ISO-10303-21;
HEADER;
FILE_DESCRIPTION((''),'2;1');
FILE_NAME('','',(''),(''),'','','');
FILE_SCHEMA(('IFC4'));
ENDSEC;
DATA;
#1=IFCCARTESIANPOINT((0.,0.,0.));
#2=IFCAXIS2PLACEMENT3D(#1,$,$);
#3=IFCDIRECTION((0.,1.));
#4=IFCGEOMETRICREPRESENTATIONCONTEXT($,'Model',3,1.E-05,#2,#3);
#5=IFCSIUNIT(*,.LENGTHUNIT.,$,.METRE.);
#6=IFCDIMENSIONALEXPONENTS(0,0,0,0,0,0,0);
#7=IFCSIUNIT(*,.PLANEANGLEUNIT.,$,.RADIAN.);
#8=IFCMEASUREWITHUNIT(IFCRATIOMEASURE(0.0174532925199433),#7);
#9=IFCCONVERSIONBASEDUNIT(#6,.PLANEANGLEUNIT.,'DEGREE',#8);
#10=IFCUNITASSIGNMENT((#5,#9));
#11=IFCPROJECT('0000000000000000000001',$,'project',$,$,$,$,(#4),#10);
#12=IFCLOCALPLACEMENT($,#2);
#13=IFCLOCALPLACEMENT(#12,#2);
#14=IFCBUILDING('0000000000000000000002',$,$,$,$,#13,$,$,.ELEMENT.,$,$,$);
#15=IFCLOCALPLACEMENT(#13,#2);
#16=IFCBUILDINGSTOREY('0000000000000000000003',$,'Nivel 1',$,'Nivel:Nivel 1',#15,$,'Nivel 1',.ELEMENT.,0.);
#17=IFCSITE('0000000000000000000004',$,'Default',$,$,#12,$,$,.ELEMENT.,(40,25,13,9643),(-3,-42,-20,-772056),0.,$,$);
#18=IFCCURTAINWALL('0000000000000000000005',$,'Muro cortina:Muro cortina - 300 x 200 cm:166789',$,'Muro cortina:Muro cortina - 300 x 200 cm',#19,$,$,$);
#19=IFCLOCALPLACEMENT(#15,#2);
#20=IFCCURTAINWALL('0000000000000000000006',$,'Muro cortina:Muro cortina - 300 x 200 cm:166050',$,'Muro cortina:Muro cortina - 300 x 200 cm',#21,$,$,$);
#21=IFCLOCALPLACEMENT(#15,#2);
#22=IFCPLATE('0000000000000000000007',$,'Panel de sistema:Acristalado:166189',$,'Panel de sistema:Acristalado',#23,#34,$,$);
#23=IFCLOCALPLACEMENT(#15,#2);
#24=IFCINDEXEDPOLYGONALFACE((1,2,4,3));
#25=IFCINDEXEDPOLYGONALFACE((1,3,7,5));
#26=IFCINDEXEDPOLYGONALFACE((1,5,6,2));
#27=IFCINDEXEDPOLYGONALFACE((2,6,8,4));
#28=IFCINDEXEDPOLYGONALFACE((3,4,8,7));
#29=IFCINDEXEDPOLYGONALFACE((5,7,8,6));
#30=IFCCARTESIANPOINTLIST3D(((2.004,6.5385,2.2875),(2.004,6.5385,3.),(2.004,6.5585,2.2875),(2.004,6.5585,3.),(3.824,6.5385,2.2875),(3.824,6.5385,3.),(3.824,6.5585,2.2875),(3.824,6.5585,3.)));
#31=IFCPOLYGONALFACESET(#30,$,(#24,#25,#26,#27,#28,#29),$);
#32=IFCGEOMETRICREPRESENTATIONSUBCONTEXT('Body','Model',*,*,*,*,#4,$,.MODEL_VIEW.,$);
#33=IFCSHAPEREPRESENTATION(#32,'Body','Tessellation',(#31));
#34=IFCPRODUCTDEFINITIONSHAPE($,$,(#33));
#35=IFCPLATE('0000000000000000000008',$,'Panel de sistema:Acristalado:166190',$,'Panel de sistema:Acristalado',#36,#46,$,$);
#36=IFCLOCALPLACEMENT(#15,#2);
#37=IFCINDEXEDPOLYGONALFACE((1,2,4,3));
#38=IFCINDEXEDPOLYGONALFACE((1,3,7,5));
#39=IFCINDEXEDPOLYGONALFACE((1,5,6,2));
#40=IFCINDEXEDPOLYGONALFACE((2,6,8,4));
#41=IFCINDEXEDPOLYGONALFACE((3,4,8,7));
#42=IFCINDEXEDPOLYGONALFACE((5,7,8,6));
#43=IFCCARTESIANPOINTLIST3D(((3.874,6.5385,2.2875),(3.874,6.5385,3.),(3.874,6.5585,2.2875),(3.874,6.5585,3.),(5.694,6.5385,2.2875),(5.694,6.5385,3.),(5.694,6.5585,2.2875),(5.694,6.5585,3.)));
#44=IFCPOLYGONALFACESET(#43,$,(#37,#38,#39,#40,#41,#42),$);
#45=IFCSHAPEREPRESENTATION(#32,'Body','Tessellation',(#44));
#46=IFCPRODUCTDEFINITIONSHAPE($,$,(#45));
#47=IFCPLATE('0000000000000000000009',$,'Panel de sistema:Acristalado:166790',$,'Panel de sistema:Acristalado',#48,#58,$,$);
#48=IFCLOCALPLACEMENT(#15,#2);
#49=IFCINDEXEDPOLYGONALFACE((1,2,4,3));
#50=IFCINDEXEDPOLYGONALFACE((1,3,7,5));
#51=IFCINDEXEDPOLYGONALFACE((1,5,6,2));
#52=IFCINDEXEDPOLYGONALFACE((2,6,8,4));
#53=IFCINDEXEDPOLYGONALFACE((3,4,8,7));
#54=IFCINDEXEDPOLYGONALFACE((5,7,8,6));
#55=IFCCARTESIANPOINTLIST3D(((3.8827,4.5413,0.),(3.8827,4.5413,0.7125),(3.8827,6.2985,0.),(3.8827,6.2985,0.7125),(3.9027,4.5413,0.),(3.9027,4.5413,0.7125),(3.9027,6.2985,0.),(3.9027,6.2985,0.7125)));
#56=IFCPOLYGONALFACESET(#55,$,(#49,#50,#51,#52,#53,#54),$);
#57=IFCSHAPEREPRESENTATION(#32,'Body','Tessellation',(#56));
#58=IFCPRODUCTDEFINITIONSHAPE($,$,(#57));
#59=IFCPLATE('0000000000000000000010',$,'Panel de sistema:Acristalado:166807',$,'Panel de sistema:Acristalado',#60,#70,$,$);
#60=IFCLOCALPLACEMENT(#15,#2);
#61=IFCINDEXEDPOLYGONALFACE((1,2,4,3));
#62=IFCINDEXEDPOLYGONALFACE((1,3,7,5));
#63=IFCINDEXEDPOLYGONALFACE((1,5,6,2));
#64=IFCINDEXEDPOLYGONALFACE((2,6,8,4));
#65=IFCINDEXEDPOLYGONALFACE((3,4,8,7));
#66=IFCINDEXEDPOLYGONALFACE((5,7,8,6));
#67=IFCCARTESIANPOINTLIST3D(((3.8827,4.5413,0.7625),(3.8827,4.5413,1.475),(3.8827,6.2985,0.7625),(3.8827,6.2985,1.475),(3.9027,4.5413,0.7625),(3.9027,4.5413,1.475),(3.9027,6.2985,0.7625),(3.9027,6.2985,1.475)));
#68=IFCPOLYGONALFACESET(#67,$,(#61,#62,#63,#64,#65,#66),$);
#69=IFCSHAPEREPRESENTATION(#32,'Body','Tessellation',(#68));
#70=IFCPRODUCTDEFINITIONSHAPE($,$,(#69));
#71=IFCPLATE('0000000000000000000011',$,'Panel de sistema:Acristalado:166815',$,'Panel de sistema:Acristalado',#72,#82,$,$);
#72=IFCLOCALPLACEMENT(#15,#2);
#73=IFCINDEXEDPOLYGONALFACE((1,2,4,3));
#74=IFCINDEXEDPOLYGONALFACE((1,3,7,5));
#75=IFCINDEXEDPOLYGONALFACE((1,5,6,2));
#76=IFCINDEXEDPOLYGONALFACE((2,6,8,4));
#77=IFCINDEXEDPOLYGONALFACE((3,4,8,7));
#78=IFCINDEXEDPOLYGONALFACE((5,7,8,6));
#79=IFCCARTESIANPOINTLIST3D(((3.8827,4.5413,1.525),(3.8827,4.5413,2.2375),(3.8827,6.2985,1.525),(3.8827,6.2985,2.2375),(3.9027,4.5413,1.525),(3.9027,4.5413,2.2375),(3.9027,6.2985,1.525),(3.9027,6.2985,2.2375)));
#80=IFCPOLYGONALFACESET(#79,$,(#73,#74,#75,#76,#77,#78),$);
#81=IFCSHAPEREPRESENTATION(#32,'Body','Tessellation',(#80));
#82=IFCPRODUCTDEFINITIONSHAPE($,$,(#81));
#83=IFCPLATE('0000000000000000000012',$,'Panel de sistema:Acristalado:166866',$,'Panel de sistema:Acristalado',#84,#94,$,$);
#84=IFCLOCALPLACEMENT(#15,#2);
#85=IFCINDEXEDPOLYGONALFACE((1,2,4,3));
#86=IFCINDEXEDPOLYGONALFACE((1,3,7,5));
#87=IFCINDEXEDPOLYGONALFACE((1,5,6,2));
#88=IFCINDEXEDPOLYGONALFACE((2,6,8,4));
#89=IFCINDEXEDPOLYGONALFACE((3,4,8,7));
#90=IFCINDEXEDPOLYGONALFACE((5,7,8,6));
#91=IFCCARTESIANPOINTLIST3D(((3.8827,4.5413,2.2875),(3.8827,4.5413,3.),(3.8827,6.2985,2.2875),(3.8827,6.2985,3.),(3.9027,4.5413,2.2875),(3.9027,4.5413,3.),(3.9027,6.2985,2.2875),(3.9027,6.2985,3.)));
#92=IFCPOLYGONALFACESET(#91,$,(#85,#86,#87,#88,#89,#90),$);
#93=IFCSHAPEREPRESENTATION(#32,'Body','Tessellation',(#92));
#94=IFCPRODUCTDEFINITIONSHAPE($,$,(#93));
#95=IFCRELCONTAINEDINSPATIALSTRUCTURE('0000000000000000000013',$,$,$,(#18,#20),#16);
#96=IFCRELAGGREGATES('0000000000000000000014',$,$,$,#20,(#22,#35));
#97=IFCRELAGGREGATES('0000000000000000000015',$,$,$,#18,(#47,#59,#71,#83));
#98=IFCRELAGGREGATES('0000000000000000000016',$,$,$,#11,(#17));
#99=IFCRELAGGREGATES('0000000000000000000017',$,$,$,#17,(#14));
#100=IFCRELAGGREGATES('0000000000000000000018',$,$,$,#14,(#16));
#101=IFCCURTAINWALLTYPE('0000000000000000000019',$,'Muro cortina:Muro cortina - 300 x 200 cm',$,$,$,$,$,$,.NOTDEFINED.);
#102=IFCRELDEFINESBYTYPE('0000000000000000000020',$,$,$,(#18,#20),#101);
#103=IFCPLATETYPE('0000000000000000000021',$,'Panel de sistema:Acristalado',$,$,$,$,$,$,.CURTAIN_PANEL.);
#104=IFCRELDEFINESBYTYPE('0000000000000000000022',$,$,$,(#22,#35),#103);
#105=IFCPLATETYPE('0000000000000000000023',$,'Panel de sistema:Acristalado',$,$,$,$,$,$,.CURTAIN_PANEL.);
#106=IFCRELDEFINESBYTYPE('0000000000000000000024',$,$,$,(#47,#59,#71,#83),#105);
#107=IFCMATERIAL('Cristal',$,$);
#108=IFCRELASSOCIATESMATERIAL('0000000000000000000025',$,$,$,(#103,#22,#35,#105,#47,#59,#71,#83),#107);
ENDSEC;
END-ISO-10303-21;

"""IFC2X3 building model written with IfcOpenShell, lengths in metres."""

from ifc_helpers import new_model, entity, si_unit, converted_unit, direction, frame, origin, origin_2d_with_axis, place, context, subcontext, project, spatial, rectangle, extrude, source, transform, mapped, material, type_object, type_shapes, element, aggregate, save


model = new_model("IFC2X3")

# Units and contexts
model_context = context("Model", 3, precision=1e-05, world=origin(), true_north=direction((0.0, 1.0)))
body_context = subcontext(model_context, "Body", "Model", "MODEL_VIEW")
ifc_project = project(units=[si_unit("LENGTHUNIT", "METRE"), converted_unit("PLANEANGLEUNIT", "DEGREE", entity("IfcRatioMeasure", 0.0174532925199433), si_unit("PLANEANGLEUNIT", "RADIAN"), dimensions=[0, 0, 0, 0, 0, 0, 0])], contexts=[model_context])

# Site, building, storey
site_placement = place(None, origin())
site = spatial("IfcSite", under=ifc_project, at=site_placement, Name="Default", CompositionType="ELEMENT", RefLatitude=(40, 25, 13, 9643), RefLongitude=(-3, -42, -20, -772056), RefElevation=0.0)
building_placement = place(site_placement, origin())
building = spatial("IfcBuilding", under=site, at=building_placement, CompositionType="ELEMENT")
storey_placement = place(building_placement, origin())
storey = spatial("IfcBuildingStorey", under=building, at=storey_placement, Name="Nivel 1", ObjectType="Nivel:Nivel 1", LongName="Nivel 1", CompositionType="ELEMENT", Elevation=0.0)

# Curtain walls
curtain_wall_type = type_object("IfcCurtainWallType", Name="Muro cortina:Muro cortina - 300 x 200 cm", PredefinedType="NOTDEFINED")
curtain_wall_1_placement = place(storey_placement, origin())
curtain_wall_1 = element("IfcCurtainWall", 1, at=curtain_wall_1_placement, inside=storey, type_object=curtain_wall_type, Name="Muro cortina:Muro cortina - 300 x 200 cm:166789", ObjectType="Muro cortina:Muro cortina - 300 x 200 cm")
curtain_wall_2_placement = place(storey_placement, origin())
curtain_wall_2 = element("IfcCurtainWall", 2, at=curtain_wall_2_placement, inside=storey, type_object=curtain_wall_type, Name="Muro cortina:Muro cortina - 300 x 200 cm:166050", ObjectType="Muro cortina:Muro cortina - 300 x 200 cm")

# Plates
ifc_material_1 = material(Name="Cristal")
plate_type_1 = type_object("IfcPlateType", Name="Panel de sistema:Acristalado", PredefinedType="CURTAIN_PANEL", material=ifc_material_1)
shared_shape_1 = source(origin(), body_context, "Body", "SweptSolid", [
    extrude(rectangle(XDim=0.02, YDim=1.82, at=origin_2d_with_axis()), frame((0.0, 0.0, 0.0), z_axis=(0.0, 0.0, 1.0), x_axis=(0.0, 1.0, 0.0)), (0.0, 0.0, 1.0), 0.7125),
])
type_shapes(plate_type_1, [shared_shape_1])
plate_1_placement = place(curtain_wall_2_placement, frame((2.914, 6.5485, 2.2875)))
plate_1 = element("IfcPlate", 3, at=plate_1_placement, type_object=plate_type_1, material=ifc_material_1, Name="Panel de sistema:Acristalado:166189", ObjectType="Panel de sistema:Acristalado", context=body_context, shape_type="MappedRepresentation", body=[
    mapped(shared_shape_1, transform((0.0, 0.0, 0.0), scale=1.0)),
])
plate_2_placement = place(curtain_wall_2_placement, frame((4.784, 6.5485, 2.2875)))
plate_2 = element("IfcPlate", 4, at=plate_2_placement, type_object=plate_type_1, material=ifc_material_1, Name="Panel de sistema:Acristalado:166190", ObjectType="Panel de sistema:Acristalado", context=body_context, shape_type="MappedRepresentation", body=[
    mapped(shared_shape_1, transform((0.0, 0.0, 0.0), scale=1.0)),
])
aggregate(curtain_wall_2, [plate_1, plate_2])
plate_type_2 = type_object("IfcPlateType", Name="Panel de sistema:Acristalado", PredefinedType="CURTAIN_PANEL", material=ifc_material_1)
shared_shape_2 = source(origin(), body_context, "Body", "SweptSolid", [
    extrude(rectangle(XDim=0.02, YDim=1.7571, at=origin_2d_with_axis()), frame((0.0, 0.0, 0.0), z_axis=(0.0, 0.0, 1.0), x_axis=(0.0, 1.0, 0.0)), (0.0, 0.0, 1.0), 0.7125),
])
type_shapes(plate_type_2, [shared_shape_2])
plate_3_placement = place(curtain_wall_1_placement, frame((3.8927, 5.4199, 0.0), z_axis=(0.0, 0.0, 1.0), x_axis=(0.0, -1.0, 0.0)))
plate_3 = element("IfcPlate", 5, at=plate_3_placement, type_object=plate_type_2, material=ifc_material_1, Name="Panel de sistema:Acristalado:166790", ObjectType="Panel de sistema:Acristalado", context=body_context, shape_type="MappedRepresentation", body=[
    mapped(shared_shape_2, transform((0.0, 0.0, 0.0), scale=1.0)),
])
plate_4_placement = place(curtain_wall_1_placement, frame((3.8927, 5.4199, 0.7625), z_axis=(0.0, 0.0, 1.0), x_axis=(0.0, -1.0, 0.0)))
plate_4 = element("IfcPlate", 6, at=plate_4_placement, type_object=plate_type_2, material=ifc_material_1, Name="Panel de sistema:Acristalado:166807", ObjectType="Panel de sistema:Acristalado", context=body_context, shape_type="MappedRepresentation", body=[
    mapped(shared_shape_2, transform((0.0, 0.0, 0.0), scale=1.0)),
])
plate_5_placement = place(curtain_wall_1_placement, frame((3.8927, 5.4199, 1.525), z_axis=(0.0, 0.0, 1.0), x_axis=(0.0, -1.0, 0.0)))
plate_5 = element("IfcPlate", 7, at=plate_5_placement, type_object=plate_type_2, material=ifc_material_1, Name="Panel de sistema:Acristalado:166815", ObjectType="Panel de sistema:Acristalado", context=body_context, shape_type="MappedRepresentation", body=[
    mapped(shared_shape_2, transform((0.0, 0.0, 0.0), scale=1.0)),
])
plate_6_placement = place(curtain_wall_1_placement, frame((3.8927, 5.4199, 2.2875), z_axis=(0.0, 0.0, 1.0), x_axis=(0.0, -1.0, 0.0)))
plate_6 = element("IfcPlate", 8, at=plate_6_placement, type_object=plate_type_2, material=ifc_material_1, Name="Panel de sistema:Acristalado:166866", ObjectType="Panel de sistema:Acristalado", context=body_context, shape_type="MappedRepresentation", body=[
    mapped(shared_shape_2, transform((0.0, 0.0, 0.0), scale=1.0)),
])
aggregate(curtain_wall_1, [plate_3, plate_4, plate_5, plate_6])

save(model, "model.ifc")
